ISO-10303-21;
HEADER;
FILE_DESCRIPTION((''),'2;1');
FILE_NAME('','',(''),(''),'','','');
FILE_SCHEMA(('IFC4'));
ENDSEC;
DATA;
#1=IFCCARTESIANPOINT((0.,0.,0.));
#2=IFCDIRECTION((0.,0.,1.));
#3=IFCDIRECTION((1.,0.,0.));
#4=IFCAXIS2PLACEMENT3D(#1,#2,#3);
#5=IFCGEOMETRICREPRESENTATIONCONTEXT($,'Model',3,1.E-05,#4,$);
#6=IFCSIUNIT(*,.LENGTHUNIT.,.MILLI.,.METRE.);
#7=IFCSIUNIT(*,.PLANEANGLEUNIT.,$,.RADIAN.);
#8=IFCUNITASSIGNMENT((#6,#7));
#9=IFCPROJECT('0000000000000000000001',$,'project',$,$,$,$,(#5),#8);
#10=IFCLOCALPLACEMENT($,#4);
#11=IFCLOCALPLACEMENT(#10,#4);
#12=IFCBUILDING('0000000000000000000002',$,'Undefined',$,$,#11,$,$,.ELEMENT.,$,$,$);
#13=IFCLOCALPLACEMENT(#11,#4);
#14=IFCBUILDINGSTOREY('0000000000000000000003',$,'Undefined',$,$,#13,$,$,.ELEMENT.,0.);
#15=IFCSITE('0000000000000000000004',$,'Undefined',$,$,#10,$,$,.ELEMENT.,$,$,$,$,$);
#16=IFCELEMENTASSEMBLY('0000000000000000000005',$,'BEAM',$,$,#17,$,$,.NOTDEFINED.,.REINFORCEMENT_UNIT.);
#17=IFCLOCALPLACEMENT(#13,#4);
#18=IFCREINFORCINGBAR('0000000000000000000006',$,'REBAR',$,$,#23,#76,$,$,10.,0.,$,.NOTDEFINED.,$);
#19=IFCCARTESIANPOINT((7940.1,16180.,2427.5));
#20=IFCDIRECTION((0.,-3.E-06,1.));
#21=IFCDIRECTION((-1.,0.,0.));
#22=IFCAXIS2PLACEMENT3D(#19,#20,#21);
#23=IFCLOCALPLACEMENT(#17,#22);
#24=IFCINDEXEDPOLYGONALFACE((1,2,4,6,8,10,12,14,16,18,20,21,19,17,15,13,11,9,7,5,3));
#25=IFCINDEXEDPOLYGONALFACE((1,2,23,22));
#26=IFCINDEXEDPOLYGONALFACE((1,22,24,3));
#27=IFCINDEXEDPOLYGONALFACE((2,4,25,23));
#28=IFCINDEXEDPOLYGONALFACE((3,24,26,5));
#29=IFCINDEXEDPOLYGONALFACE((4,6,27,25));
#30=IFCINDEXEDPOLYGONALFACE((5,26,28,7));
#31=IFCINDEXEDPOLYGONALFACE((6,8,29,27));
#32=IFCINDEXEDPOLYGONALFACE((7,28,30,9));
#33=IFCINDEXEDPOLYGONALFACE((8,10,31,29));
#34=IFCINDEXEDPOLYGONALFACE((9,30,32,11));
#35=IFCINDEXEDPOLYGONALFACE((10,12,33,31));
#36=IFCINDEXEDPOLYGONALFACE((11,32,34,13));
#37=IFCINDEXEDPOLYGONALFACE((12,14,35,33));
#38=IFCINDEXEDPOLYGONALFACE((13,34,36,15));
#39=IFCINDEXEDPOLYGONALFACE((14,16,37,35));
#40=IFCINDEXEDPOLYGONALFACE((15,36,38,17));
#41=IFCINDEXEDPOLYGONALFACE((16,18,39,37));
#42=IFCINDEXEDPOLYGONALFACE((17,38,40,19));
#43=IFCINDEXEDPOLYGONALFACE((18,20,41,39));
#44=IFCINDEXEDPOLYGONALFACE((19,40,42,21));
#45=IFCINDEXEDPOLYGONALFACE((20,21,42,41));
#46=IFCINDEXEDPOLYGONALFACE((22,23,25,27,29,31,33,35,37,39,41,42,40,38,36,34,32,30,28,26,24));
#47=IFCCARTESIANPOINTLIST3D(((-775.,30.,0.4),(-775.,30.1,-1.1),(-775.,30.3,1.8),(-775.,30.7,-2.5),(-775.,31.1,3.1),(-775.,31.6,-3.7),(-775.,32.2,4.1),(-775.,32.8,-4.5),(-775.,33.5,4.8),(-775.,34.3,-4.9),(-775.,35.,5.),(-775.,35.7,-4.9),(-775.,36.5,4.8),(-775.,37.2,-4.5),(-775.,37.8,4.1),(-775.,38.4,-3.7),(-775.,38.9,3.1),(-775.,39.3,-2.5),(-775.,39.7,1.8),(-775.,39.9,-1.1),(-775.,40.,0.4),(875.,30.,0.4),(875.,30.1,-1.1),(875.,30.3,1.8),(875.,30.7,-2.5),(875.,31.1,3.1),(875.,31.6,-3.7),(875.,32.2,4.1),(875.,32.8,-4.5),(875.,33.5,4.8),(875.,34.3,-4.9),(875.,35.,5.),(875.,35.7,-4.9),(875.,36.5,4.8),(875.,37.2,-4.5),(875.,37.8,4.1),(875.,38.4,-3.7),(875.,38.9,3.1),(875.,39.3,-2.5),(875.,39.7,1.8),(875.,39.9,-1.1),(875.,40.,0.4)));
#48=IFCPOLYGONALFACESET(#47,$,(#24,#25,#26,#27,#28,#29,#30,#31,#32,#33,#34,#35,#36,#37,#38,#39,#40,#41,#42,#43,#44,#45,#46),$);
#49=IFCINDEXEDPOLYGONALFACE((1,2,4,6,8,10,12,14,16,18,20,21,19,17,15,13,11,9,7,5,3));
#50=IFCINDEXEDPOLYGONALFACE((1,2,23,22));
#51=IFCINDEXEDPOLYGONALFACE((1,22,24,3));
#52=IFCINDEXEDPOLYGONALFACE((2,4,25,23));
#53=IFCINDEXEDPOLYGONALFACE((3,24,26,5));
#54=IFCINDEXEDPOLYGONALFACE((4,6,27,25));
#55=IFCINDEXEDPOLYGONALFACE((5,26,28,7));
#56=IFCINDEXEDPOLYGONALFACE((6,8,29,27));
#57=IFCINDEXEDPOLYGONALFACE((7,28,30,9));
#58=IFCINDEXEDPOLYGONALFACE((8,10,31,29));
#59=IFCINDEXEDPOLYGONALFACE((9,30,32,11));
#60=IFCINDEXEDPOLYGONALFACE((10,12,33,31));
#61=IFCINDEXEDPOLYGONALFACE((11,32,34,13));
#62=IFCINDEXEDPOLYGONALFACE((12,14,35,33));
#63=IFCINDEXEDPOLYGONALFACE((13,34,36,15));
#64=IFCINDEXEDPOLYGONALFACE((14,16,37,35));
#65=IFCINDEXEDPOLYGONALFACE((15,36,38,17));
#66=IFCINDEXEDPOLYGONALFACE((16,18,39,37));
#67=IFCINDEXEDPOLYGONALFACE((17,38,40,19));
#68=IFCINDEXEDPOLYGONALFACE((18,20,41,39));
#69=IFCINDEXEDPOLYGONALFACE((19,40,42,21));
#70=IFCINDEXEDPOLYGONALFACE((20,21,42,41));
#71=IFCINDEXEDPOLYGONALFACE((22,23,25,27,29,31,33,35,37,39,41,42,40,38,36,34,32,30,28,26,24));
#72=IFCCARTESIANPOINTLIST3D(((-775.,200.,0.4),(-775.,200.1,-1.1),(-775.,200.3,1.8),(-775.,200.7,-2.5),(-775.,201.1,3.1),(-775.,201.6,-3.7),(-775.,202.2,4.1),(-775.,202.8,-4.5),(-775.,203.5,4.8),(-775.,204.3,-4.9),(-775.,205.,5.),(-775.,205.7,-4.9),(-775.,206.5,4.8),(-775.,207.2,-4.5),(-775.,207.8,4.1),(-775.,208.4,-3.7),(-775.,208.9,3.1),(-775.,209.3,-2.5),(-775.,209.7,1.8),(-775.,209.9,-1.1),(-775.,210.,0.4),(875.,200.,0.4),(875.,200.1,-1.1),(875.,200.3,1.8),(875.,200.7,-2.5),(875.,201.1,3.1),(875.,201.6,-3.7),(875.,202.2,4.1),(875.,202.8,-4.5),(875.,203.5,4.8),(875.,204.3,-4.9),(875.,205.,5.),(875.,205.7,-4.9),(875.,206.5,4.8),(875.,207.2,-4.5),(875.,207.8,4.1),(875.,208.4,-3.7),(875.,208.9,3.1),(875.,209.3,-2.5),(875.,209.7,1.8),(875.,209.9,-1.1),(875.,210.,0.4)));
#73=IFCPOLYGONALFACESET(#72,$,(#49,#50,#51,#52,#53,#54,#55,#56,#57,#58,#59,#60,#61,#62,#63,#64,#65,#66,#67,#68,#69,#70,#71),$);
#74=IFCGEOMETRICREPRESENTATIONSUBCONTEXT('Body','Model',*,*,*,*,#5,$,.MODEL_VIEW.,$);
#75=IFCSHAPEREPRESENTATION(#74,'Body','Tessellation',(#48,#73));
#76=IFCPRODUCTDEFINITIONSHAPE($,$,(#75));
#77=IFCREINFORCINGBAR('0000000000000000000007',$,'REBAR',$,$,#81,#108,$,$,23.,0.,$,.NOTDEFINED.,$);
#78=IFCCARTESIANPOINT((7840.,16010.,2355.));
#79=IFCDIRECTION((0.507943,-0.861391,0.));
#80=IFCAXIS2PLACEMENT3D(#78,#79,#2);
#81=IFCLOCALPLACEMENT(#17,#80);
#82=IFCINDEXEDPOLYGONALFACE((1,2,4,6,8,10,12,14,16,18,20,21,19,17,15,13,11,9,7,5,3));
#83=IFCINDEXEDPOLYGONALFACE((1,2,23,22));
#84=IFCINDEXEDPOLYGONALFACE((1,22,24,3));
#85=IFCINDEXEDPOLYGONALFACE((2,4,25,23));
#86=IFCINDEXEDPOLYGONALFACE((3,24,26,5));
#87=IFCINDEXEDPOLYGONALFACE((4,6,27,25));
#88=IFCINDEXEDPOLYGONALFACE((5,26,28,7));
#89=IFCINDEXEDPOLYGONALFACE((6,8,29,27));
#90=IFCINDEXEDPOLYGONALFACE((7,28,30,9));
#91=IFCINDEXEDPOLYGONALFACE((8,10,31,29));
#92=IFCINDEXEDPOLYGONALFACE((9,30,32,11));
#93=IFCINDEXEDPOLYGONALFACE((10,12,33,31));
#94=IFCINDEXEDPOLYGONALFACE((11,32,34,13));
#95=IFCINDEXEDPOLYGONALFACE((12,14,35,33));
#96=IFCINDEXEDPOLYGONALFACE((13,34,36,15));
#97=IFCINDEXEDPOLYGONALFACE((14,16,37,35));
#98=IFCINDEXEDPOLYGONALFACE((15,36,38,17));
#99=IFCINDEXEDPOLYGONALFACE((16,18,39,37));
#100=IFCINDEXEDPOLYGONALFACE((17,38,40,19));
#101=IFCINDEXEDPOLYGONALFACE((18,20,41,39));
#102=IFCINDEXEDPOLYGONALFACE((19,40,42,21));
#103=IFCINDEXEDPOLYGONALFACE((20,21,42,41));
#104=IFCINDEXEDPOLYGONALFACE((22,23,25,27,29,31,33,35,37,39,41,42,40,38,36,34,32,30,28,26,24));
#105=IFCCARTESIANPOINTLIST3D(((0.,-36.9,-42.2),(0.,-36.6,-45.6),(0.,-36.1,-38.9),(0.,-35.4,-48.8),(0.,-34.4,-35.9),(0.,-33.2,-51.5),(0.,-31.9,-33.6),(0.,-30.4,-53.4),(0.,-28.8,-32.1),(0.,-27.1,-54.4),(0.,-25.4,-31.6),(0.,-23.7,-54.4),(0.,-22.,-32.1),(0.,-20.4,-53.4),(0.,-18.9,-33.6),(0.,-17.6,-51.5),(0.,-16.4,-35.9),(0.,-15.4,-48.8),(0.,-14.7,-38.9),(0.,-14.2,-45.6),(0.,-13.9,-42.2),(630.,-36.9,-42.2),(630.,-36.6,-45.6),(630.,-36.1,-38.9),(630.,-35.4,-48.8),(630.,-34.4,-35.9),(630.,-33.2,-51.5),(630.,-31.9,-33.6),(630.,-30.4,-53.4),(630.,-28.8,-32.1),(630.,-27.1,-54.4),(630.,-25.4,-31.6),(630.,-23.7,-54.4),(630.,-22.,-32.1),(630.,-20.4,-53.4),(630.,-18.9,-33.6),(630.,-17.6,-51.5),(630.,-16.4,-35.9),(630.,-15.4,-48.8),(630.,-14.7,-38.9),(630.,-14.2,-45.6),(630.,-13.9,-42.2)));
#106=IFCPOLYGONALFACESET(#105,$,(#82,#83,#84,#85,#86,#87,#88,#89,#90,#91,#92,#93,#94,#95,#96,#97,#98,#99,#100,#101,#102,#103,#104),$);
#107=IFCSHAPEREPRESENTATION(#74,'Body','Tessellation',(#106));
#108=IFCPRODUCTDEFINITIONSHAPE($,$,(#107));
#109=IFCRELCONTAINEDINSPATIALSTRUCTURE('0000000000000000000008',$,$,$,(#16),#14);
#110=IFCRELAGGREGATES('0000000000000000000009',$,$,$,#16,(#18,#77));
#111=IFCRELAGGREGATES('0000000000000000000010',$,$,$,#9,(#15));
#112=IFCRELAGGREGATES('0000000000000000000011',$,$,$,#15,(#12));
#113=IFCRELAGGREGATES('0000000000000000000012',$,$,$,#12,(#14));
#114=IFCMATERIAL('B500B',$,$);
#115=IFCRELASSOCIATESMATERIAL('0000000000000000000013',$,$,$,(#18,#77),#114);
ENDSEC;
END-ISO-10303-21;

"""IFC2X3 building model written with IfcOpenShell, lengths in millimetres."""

from ifc_helpers import new_model, entity, si_unit, frame, origin_with_axes, place, context, subcontext, project, spatial, source, transform, mapped, material, element, aggregate, save


model = new_model("IFC2X3")

# Units and contexts
model_context = context("Model", 3, precision=1e-05, world=origin_with_axes())
body_context = subcontext(model_context, "Body", "Model", "MODEL_VIEW")
ifc_project = project(units=[si_unit("LENGTHUNIT", "METRE", prefix="MILLI"), si_unit("PLANEANGLEUNIT", "RADIAN")], contexts=[model_context])

# Site, building, storey
site_placement = place(None, origin_with_axes())
site = spatial("IfcSite", under=ifc_project, at=site_placement, Name="Undefined", CompositionType="ELEMENT")
building_placement = place(site_placement, origin_with_axes())
building = spatial("IfcBuilding", under=site, at=building_placement, Name="Undefined", CompositionType="ELEMENT")
storey_placement = place(building_placement, origin_with_axes())
storey = spatial("IfcBuildingStorey", under=building, at=storey_placement, Name="Undefined", CompositionType="ELEMENT", Elevation=0.0)

# Element assembly
assembly_1_placement = place(storey_placement, origin_with_axes())
assembly_1 = element("IfcElementAssembly", 1, at=assembly_1_placement, inside=storey, Name="BEAM", AssemblyPlace="NOTDEFINED", PredefinedType="REINFORCEMENT_UNIT")

# Shared definitions
ifc_material_1 = material(Name="B500B")

# Reinforcing bars
shared_shape_1 = source(origin_with_axes(), body_context, "Body", "AdvancedSweptSolid", [
    entity("IfcSweptDiskSolid", entity("IfcTrimmedCurve", entity("IfcLine", entity("IfcCartesianPoint", [0.0, 0.0, 0.0]), entity("IfcVector", entity("IfcDirection", [1.0, 0.0, 0.0]), 1.0)), [entity("IfcParameterValue", 0.0)], [entity("IfcParameterValue", 1649.999613)], True, "PARAMETER"), 5.0, None, 0.0, 1650.0),
])
shared_shape_2 = source(origin_with_axes(), body_context, "Body", "AdvancedSweptSolid", [
    entity("IfcSweptDiskSolid", entity("IfcTrimmedCurve", entity("IfcLine", entity("IfcCartesianPoint", [0.0, 0.0, 0.0]), entity("IfcVector", entity("IfcDirection", [1.0, 0.0, 0.0]), 1.0)), [entity("IfcParameterValue", 0.0)], [entity("IfcParameterValue", 1649.999613)], True, "PARAMETER"), 5.0, None, 0.0, 1650.0),
])
reinforcing_bar_1_placement = place(assembly_1_placement, frame((7940.1, 16180.0, 2427.5), z_axis=(0.0, -0.000003, 1.0), x_axis=(-1.0, 0.0, 0.0)))
reinforcing_bar_1 = element("IfcReinforcingBar", 2, at=reinforcing_bar_1_placement, material=ifc_material_1, Name="REBAR", BarRole="NOTDEFINED", CrossSectionArea=0.0, NominalDiameter=10.0, context=body_context, shape_type="MappedRepresentation", body=[
    mapped(shared_shape_1, transform((-775.0, 35.0, 0.0))),
    mapped(shared_shape_2, transform((-775.0, 205.0, 0.0))),
])
shared_shape_3 = source(origin_with_axes(), body_context, "Body", "AdvancedSweptSolid", [
    entity("IfcSweptDiskSolid", entity("IfcTrimmedCurve", entity("IfcLine", entity("IfcCartesianPoint", [0.0, 0.0, 0.0]), entity("IfcVector", entity("IfcDirection", [1.0, 0.0, 0.0]), 1.0)), [entity("IfcParameterValue", 0.0)], [entity("IfcParameterValue", 630.0)], True, "PARAMETER"), 11.5, None, 0.0, 630.0),
])
reinforcing_bar_2_placement = place(assembly_1_placement, frame((7840.0, 16010.0, 2355.0), z_axis=(0.507943, -0.861391, 0.0), x_axis=(0.0, 0.0, 1.0)))
reinforcing_bar_2 = element("IfcReinforcingBar", 3, at=reinforcing_bar_2_placement, material=ifc_material_1, Name="REBAR", BarRole="NOTDEFINED", CrossSectionArea=0.0, NominalDiameter=23.0, context=body_context, shape_type="MappedRepresentation", body=[
    mapped(shared_shape_3, transform((0.0, -25.4, -43.1))),
])
aggregate(assembly_1, [reinforcing_bar_1, reinforcing_bar_2])

save(model, "model.ifc")
